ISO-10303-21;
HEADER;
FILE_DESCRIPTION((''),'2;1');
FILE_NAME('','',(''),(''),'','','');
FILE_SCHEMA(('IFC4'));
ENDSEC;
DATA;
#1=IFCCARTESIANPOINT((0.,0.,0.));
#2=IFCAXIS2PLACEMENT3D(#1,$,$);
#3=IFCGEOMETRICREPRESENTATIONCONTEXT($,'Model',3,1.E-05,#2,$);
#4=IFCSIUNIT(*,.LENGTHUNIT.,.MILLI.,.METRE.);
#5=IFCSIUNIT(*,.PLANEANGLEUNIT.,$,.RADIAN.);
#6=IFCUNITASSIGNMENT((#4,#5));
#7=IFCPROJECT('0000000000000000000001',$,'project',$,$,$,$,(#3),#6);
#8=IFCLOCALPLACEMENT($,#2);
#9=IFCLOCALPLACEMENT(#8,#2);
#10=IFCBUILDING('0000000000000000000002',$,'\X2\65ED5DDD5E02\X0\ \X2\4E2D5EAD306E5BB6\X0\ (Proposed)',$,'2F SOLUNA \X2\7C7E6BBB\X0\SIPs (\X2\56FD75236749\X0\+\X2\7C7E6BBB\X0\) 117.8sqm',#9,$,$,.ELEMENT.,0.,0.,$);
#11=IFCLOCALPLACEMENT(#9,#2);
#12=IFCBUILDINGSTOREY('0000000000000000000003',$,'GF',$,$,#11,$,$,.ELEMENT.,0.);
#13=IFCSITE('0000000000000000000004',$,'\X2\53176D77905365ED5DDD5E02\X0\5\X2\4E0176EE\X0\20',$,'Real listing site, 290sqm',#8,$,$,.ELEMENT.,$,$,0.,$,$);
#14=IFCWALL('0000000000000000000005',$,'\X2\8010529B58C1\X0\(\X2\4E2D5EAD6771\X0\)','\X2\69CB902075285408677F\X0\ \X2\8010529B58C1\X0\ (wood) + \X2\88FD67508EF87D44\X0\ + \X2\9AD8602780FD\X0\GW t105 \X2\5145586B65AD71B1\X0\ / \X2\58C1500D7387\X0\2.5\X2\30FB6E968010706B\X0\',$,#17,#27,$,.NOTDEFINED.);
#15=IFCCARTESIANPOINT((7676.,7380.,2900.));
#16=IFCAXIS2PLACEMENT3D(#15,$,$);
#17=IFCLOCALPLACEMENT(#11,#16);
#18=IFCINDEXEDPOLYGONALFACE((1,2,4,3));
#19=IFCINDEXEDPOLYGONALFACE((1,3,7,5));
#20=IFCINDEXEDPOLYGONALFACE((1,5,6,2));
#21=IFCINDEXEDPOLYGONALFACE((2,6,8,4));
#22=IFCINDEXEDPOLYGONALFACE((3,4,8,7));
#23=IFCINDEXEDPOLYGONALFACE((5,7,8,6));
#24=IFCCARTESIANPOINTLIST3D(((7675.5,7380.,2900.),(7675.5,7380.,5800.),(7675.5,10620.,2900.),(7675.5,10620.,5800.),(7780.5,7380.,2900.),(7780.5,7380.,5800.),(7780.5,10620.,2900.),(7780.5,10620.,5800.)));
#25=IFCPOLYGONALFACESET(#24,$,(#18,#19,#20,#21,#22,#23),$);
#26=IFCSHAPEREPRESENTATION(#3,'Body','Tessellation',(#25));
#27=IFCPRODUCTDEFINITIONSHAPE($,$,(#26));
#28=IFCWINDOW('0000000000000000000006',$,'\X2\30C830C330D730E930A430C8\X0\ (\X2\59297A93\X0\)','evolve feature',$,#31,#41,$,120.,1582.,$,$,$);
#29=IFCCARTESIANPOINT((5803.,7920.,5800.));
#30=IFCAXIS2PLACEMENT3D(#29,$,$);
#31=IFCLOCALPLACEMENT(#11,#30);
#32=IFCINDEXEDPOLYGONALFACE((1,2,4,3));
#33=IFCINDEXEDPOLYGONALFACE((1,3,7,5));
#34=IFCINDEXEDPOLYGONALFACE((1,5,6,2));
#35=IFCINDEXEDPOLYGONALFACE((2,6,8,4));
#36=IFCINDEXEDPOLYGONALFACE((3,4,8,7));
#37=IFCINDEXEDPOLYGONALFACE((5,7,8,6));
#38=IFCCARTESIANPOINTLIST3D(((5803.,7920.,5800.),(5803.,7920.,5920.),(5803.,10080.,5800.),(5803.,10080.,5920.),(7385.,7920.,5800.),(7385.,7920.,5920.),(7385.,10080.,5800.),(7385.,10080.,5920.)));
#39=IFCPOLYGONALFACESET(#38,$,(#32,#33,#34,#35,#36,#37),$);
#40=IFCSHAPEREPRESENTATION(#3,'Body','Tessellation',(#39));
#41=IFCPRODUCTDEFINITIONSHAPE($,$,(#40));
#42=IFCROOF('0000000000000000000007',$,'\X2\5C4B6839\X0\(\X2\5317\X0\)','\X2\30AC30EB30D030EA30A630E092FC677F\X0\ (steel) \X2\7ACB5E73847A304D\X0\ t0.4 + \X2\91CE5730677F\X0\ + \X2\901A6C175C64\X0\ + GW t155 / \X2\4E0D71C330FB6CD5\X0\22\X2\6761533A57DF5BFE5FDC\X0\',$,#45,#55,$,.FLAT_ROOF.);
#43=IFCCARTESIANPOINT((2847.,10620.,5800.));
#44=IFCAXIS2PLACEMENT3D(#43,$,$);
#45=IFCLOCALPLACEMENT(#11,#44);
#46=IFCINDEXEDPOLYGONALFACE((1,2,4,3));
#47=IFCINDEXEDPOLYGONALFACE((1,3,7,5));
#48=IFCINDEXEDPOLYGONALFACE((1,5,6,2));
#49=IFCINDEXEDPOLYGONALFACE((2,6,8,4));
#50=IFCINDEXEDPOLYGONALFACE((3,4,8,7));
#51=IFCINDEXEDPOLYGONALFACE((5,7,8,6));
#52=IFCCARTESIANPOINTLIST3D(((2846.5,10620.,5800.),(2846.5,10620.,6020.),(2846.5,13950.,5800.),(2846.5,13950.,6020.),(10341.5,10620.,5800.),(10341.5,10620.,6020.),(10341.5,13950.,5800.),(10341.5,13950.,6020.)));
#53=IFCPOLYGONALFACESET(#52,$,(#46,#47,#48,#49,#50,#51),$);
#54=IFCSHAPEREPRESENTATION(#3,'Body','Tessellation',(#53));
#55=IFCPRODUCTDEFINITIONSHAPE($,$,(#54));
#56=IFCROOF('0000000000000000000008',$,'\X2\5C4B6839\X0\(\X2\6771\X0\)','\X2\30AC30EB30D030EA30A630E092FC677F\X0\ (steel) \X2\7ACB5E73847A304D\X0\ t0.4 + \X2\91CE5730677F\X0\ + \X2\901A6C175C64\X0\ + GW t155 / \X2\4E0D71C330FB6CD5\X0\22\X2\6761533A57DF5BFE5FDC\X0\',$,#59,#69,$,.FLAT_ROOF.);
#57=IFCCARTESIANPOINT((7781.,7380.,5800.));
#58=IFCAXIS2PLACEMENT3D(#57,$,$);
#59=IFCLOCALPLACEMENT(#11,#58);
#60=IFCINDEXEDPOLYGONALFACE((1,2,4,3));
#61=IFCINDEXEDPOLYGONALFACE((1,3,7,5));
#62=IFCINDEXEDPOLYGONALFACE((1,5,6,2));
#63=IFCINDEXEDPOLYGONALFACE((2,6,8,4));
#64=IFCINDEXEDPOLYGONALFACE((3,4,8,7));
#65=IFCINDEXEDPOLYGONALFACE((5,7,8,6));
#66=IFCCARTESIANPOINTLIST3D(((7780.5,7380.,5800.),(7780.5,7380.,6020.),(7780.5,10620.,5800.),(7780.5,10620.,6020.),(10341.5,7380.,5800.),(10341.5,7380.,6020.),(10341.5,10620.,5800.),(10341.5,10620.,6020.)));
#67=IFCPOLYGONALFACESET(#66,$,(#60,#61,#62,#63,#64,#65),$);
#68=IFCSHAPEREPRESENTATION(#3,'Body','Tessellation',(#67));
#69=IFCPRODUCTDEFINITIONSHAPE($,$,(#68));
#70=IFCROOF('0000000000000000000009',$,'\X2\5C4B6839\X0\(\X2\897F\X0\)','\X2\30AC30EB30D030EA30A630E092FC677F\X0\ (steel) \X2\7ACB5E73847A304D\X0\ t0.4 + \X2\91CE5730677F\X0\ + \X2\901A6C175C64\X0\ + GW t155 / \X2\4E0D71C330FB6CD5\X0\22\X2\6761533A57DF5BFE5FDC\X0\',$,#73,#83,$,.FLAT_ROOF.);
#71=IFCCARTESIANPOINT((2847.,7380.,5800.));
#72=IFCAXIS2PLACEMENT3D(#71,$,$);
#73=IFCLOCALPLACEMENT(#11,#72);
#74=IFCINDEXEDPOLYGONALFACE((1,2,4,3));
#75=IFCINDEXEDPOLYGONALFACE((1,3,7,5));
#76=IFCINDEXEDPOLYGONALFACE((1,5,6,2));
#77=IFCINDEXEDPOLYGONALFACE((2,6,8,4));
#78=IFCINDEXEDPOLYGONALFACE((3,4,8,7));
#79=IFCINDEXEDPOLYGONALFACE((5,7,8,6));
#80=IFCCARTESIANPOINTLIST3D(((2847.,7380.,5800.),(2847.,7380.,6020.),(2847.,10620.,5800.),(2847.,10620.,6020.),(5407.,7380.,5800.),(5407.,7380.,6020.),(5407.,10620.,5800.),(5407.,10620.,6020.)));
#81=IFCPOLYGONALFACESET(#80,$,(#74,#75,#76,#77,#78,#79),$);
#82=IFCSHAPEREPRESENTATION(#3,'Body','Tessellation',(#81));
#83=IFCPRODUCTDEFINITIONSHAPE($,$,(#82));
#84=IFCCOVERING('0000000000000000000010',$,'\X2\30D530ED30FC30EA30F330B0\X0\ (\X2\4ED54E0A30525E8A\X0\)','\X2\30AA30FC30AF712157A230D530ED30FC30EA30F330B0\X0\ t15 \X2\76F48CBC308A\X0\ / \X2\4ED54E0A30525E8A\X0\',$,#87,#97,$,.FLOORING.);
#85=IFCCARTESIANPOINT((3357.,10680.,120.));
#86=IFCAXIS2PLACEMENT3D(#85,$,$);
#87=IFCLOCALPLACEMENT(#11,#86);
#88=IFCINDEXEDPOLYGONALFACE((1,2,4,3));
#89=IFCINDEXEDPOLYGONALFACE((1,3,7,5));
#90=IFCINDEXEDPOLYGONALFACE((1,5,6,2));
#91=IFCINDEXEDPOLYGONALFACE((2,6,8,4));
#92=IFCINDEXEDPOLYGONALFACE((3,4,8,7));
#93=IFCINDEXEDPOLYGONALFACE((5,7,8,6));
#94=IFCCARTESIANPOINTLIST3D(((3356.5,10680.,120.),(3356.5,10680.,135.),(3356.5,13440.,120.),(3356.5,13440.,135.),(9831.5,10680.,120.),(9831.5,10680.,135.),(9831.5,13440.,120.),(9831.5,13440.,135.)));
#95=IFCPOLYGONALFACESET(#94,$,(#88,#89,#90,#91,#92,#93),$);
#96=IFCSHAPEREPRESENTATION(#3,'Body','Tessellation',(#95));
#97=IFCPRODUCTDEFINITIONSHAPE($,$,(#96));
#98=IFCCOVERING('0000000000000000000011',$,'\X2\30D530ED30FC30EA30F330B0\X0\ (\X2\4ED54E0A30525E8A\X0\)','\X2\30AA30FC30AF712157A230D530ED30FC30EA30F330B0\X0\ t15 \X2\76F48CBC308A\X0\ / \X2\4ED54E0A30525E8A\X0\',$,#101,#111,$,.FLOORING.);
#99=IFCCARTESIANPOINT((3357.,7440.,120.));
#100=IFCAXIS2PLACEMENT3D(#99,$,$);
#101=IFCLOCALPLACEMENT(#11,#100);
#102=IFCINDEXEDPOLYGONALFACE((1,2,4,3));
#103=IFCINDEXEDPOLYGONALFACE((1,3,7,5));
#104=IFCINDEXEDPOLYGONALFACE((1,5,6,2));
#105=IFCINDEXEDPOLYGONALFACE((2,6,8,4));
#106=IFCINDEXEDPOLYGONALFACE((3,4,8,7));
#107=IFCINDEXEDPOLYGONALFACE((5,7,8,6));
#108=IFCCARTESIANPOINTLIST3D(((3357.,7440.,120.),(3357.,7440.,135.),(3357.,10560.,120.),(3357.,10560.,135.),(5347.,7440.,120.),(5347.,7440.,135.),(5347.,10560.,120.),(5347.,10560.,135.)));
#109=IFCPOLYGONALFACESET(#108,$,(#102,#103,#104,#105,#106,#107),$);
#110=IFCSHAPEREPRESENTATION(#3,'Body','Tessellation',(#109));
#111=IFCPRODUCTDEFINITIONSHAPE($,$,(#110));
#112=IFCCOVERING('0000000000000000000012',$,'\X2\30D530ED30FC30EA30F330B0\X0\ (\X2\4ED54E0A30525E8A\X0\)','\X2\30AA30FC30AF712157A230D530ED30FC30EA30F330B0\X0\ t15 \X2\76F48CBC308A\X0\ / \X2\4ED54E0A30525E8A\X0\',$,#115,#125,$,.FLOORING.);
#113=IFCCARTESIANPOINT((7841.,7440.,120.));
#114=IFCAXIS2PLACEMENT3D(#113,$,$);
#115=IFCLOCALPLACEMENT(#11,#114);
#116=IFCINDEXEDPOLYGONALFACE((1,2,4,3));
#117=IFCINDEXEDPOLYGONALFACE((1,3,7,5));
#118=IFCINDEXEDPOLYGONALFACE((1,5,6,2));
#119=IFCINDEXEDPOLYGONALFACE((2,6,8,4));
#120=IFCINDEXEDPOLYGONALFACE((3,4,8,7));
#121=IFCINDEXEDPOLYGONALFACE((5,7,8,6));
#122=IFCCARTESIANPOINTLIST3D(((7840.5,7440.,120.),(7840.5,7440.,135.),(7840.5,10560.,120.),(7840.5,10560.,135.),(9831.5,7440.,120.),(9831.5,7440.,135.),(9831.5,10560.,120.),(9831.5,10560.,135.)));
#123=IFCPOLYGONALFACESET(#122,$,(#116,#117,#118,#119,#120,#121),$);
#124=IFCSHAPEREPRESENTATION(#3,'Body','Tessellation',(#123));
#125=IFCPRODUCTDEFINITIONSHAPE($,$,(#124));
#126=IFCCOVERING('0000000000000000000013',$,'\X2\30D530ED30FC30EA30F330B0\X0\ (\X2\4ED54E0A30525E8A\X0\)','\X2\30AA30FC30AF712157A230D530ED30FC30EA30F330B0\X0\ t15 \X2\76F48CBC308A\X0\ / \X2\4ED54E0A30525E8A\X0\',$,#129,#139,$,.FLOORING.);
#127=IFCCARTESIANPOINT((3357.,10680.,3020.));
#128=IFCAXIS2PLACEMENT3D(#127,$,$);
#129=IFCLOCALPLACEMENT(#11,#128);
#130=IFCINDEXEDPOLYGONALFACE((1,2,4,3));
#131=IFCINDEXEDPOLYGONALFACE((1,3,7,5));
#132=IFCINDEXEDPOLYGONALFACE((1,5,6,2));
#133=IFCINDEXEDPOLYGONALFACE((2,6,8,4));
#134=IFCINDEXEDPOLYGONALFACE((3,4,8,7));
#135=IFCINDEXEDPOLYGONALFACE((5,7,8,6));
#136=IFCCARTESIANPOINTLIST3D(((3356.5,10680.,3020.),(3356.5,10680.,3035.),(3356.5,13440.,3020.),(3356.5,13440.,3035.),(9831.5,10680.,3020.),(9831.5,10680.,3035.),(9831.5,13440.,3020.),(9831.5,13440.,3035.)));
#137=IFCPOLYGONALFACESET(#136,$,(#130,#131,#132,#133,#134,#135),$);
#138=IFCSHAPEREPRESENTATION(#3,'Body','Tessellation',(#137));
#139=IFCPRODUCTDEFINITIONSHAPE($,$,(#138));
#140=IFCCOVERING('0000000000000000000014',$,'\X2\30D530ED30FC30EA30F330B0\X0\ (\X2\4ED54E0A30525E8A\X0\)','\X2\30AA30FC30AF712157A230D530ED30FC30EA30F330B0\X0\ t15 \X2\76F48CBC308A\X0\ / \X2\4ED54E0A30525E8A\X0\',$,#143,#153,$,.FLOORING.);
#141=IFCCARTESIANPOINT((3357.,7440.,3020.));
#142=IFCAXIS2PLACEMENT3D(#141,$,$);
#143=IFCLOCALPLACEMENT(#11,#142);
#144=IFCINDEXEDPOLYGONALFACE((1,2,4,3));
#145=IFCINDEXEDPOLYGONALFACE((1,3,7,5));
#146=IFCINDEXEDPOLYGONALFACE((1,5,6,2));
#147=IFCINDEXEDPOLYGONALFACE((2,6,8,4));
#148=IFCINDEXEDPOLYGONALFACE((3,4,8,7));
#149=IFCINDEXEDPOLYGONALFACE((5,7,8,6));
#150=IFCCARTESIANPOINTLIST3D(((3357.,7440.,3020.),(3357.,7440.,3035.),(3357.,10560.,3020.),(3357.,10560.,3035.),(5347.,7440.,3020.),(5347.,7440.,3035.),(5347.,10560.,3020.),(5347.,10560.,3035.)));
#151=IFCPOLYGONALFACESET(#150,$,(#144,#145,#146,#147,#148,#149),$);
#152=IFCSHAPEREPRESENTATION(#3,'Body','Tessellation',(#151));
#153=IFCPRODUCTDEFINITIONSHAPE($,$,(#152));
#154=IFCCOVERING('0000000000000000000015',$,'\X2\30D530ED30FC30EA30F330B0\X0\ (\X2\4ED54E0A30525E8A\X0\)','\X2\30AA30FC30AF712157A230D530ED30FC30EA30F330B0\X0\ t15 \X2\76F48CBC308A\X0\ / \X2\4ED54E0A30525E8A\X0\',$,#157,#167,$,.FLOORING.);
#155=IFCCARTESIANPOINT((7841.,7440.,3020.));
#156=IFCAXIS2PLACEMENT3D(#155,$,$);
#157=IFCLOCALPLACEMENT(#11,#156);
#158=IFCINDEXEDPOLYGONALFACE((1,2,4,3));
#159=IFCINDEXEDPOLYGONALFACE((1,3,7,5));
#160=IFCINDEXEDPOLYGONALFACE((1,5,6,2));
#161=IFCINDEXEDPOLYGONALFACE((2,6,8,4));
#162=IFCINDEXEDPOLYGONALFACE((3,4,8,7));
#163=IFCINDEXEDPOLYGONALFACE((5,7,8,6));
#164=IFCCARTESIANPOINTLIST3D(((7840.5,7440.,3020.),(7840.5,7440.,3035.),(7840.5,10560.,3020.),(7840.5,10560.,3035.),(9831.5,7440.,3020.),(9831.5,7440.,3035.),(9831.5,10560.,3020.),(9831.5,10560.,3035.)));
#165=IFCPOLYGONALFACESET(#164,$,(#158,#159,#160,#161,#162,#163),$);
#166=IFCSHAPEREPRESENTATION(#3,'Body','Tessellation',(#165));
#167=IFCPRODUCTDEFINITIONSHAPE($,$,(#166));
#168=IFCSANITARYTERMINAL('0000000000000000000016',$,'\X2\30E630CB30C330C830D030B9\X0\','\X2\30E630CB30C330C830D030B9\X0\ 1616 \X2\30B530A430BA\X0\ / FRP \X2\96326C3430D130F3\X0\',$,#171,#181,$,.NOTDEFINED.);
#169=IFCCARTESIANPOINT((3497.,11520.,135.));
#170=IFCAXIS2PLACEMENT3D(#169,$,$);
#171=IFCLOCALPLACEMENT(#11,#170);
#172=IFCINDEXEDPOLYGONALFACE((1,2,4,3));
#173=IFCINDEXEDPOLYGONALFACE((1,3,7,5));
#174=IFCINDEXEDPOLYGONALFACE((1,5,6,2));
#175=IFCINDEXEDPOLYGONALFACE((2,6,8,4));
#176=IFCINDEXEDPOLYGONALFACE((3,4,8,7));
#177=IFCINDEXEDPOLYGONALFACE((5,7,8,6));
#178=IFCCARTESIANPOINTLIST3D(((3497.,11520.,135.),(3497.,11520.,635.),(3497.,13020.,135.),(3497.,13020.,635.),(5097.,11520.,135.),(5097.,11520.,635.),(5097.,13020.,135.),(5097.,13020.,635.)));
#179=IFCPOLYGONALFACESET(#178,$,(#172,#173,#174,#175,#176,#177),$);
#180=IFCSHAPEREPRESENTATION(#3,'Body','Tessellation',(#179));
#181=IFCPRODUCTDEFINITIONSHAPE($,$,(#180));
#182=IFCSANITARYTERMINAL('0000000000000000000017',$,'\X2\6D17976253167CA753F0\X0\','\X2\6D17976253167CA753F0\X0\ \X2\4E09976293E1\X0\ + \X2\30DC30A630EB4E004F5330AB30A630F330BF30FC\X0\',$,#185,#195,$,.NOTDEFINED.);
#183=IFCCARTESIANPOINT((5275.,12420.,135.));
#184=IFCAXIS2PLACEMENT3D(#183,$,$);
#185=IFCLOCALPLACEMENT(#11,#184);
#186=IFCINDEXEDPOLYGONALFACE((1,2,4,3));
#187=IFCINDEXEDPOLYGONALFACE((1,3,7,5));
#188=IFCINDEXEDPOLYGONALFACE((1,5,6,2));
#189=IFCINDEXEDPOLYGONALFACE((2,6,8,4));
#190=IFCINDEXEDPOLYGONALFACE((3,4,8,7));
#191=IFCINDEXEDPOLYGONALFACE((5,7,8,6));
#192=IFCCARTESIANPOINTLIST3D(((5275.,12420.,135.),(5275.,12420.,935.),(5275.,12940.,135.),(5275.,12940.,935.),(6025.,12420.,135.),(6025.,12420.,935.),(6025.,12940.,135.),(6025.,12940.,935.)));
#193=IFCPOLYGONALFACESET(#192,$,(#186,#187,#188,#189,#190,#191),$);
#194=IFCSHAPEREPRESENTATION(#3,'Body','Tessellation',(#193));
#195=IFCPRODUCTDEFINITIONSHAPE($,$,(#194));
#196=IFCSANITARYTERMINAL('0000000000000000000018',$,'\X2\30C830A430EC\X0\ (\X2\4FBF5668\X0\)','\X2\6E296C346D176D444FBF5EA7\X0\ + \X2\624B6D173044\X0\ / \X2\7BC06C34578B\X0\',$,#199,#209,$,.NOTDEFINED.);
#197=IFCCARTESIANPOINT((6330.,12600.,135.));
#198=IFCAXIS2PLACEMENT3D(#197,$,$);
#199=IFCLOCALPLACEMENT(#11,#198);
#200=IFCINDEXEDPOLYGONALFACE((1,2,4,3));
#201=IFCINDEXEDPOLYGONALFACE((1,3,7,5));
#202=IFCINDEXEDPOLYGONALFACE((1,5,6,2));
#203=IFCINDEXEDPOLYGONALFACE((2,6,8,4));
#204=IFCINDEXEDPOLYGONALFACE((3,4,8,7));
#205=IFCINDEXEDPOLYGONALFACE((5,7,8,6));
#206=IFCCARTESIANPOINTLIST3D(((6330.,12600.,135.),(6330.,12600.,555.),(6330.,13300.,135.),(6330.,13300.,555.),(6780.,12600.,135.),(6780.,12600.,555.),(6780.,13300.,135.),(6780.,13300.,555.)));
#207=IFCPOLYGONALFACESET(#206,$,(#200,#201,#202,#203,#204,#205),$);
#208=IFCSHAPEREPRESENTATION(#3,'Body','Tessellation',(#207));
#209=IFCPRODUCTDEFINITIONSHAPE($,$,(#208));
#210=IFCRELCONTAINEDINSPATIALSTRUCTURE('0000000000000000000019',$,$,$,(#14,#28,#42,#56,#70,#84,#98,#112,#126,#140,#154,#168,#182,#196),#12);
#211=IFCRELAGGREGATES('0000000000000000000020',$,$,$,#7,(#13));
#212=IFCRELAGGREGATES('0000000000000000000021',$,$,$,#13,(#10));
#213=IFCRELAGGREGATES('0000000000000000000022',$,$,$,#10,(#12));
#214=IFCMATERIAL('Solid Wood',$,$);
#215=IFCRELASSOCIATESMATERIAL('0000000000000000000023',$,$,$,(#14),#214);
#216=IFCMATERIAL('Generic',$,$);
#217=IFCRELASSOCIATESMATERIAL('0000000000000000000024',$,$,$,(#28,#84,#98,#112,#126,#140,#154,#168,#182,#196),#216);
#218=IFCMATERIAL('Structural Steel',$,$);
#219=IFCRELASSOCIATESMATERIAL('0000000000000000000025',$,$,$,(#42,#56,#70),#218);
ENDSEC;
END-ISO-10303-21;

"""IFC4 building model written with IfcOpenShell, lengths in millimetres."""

from ifc_helpers import new_model, si_unit, frame, frame_2d, origin, place, context, project, spatial, rectangle, extrude, material, element, save


model = new_model("IFC4")

# Units and contexts
model_context = context("Model", 3, precision=1e-05, world=origin())
ifc_project = project(units=[si_unit("LENGTHUNIT", "METRE", prefix="MILLI"), si_unit("PLANEANGLEUNIT", "RADIAN")], contexts=[model_context])

# Site, building, storey
site_placement = place(None, origin())
site = spatial("IfcSite", under=ifc_project, at=site_placement, Name="北海道旭川市5丁目20", ObjectType="Real listing site, 290sqm", CompositionType="ELEMENT", RefElevation=0.0)
building_placement = place(site_placement, origin())
building = spatial("IfcBuilding", under=site, at=building_placement, Name="旭川市 中庭の家 (Proposed)", ObjectType="2F SOLUNA 籾殻SIPs (国産杉+籾殻) 117.8sqm", CompositionType="ELEMENT", ElevationOfRefHeight=0.0, ElevationOfTerrain=0.0)
storey_placement = place(building_placement, origin())
storey = spatial("IfcBuildingStorey", under=building, at=storey_placement, Name="GF", CompositionType="ELEMENT", Elevation=0.0)

# Shared definitions
ifc_material_1 = material(Name="Solid Wood")

# Wall
wall_1_placement = place(storey_placement, frame((7676.0, 7380.0, 2900.0)))
element("IfcWall", 1, at=wall_1_placement, inside=storey, material=ifc_material_1, Name="耐力壁(中庭東)", Description="構造用合板 耐力壁 (wood) + 製材軸組 + 高性能GW t105 充填断熱 / 壁倍率2.5・準耐火", PredefinedType="NOTDEFINED", context=model_context, shape_type="SweptSolid", body=[
    extrude(rectangle(XDim=105.0, YDim=3240.0, at=frame_2d((52.0, 1620.0))), frame((7676.0, 7380.0, 2900.0)), (0.0, 0.0, 1.0), 2900.0),
])

# Window
ifc_material_2 = material(Name="Generic")
window_1_placement = place(storey_placement, frame((5803.0, 7920.0, 5800.0)))
element("IfcWindow", 2, at=window_1_placement, inside=storey, material=ifc_material_2, Name="トップライト (天窓)", Description="evolve feature", OverallHeight=120.0, OverallWidth=1582.0, context=model_context, shape_type="SweptSolid", body=[
    extrude(rectangle(XDim=1582.0, YDim=2160.0, at=frame_2d((791.0, 1080.0))), frame((5803.0, 7920.0, 5800.0)), (0.0, 0.0, 1.0), 120.0),
])

# Roofs
ifc_material_3 = material(Name="Structural Steel")
roof_1_placement = place(storey_placement, frame((2847.0, 10620.0, 5800.0)))
element("IfcRoof", 3, at=roof_1_placement, inside=storey, material=ifc_material_3, Name="屋根(北)", Description="ガルバリウム鋼板 (steel) 立平葺き t0.4 + 野地板 + 通気層 + GW t155 / 不燃・法22条区域対応", PredefinedType="FLAT_ROOF", context=model_context, shape_type="SweptSolid", body=[
    extrude(rectangle(XDim=7495.0, YDim=3330.0, at=frame_2d((3747.0, 1665.0))), frame((2847.0, 10620.0, 5800.0)), (0.0, 0.0, 1.0), 220.0),
])
roof_2_placement = place(storey_placement, frame((7781.0, 7380.0, 5800.0)))
element("IfcRoof", 4, at=roof_2_placement, inside=storey, material=ifc_material_3, Name="屋根(東)", Description="ガルバリウム鋼板 (steel) 立平葺き t0.4 + 野地板 + 通気層 + GW t155 / 不燃・法22条区域対応", PredefinedType="FLAT_ROOF", context=model_context, shape_type="SweptSolid", body=[
    extrude(rectangle(XDim=2561.0, YDim=3240.0, at=frame_2d((1280.0, 1620.0))), frame((7781.0, 7380.0, 5800.0)), (0.0, 0.0, 1.0), 220.0),
])
roof_3_placement = place(storey_placement, frame((2847.0, 7380.0, 5800.0)))
element("IfcRoof", 5, at=roof_3_placement, inside=storey, material=ifc_material_3, Name="屋根(西)", Description="ガルバリウム鋼板 (steel) 立平葺き t0.4 + 野地板 + 通気層 + GW t155 / 不燃・法22条区域対応", PredefinedType="FLAT_ROOF", context=model_context, shape_type="SweptSolid", body=[
    extrude(rectangle(XDim=2560.0, YDim=3240.0, at=frame_2d((1280.0, 1620.0))), frame((2847.0, 7380.0, 5800.0)), (0.0, 0.0, 1.0), 220.0),
])

# Coverings
covering_1_placement = place(storey_placement, frame((3357.0, 10680.0, 120.0)))
element("IfcCovering", 6, at=covering_1_placement, inside=storey, material=ifc_material_2, Name="フローリング (仕上げ床)", Description="オーク無垢フローリング t15 直貼り / 仕上げ床", PredefinedType="FLOORING", context=model_context, shape_type="SweptSolid", body=[
    extrude(rectangle(XDim=6475.0, YDim=2760.0, at=frame_2d((3237.0, 1380.0))), frame((3357.0, 10680.0, 120.0)), (0.0, 0.0, 1.0), 15.0),
])
covering_2_placement = place(storey_placement, frame((3357.0, 7440.0, 120.0)))
element("IfcCovering", 7, at=covering_2_placement, inside=storey, material=ifc_material_2, Name="フローリング (仕上げ床)", Description="オーク無垢フローリング t15 直貼り / 仕上げ床", PredefinedType="FLOORING", context=model_context, shape_type="SweptSolid", body=[
    extrude(rectangle(XDim=1990.0, YDim=3120.0, at=frame_2d((995.0, 1560.0))), frame((3357.0, 7440.0, 120.0)), (0.0, 0.0, 1.0), 15.0),
])
covering_3_placement = place(storey_placement, frame((7841.0, 7440.0, 120.0)))
element("IfcCovering", 8, at=covering_3_placement, inside=storey, material=ifc_material_2, Name="フローリング (仕上げ床)", Description="オーク無垢フローリング t15 直貼り / 仕上げ床", PredefinedType="FLOORING", context=model_context, shape_type="SweptSolid", body=[
    extrude(rectangle(XDim=1991.0, YDim=3120.0, at=frame_2d((995.0, 1560.0))), frame((7841.0, 7440.0, 120.0)), (0.0, 0.0, 1.0), 15.0),
])
covering_4_placement = place(storey_placement, frame((3357.0, 10680.0, 3020.0)))
element("IfcCovering", 9, at=covering_4_placement, inside=storey, material=ifc_material_2, Name="フローリング (仕上げ床)", Description="オーク無垢フローリング t15 直貼り / 仕上げ床", PredefinedType="FLOORING", context=model_context, shape_type="SweptSolid", body=[
    extrude(rectangle(XDim=6475.0, YDim=2760.0, at=frame_2d((3237.0, 1380.0))), frame((3357.0, 10680.0, 3020.0)), (0.0, 0.0, 1.0), 15.0),
])
covering_5_placement = place(storey_placement, frame((3357.0, 7440.0, 3020.0)))
element("IfcCovering", 10, at=covering_5_placement, inside=storey, material=ifc_material_2, Name="フローリング (仕上げ床)", Description="オーク無垢フローリング t15 直貼り / 仕上げ床", PredefinedType="FLOORING", context=model_context, shape_type="SweptSolid", body=[
    extrude(rectangle(XDim=1990.0, YDim=3120.0, at=frame_2d((995.0, 1560.0))), frame((3357.0, 7440.0, 3020.0)), (0.0, 0.0, 1.0), 15.0),
])
covering_6_placement = place(storey_placement, frame((7841.0, 7440.0, 3020.0)))
element("IfcCovering", 11, at=covering_6_placement, inside=storey, material=ifc_material_2, Name="フローリング (仕上げ床)", Description="オーク無垢フローリング t15 直貼り / 仕上げ床", PredefinedType="FLOORING", context=model_context, shape_type="SweptSolid", body=[
    extrude(rectangle(XDim=1991.0, YDim=3120.0, at=frame_2d((995.0, 1560.0))), frame((7841.0, 7440.0, 3020.0)), (0.0, 0.0, 1.0), 15.0),
])

# Sanitary terminals
sanitary_terminal_1_placement = place(storey_placement, frame((3497.0, 11520.0, 135.0)))
element("IfcSanitaryTerminal", 12, at=sanitary_terminal_1_placement, inside=storey, material=ifc_material_2, Name="ユニットバス", Description="ユニットバス 1616 サイズ / FRP 防水パン", PredefinedType="NOTDEFINED", context=model_context, shape_type="SweptSolid", body=[
    extrude(rectangle(XDim=1600.0, YDim=1500.0, at=frame_2d((800.0, 750.0))), frame((3497.0, 11520.0, 135.0)), (0.0, 0.0, 1.0), 500.0),
])
sanitary_terminal_2_placement = place(storey_placement, frame((5275.0, 12420.0, 135.0)))
element("IfcSanitaryTerminal", 13, at=sanitary_terminal_2_placement, inside=storey, material=ifc_material_2, Name="洗面化粧台", Description="洗面化粧台 三面鏡 + ボウル一体カウンター", PredefinedType="NOTDEFINED", context=model_context, shape_type="SweptSolid", body=[
    extrude(rectangle(XDim=750.0, YDim=520.0, at=frame_2d((375.0, 260.0))), frame((5275.0, 12420.0, 135.0)), (0.0, 0.0, 1.0), 800.0),
])
sanitary_terminal_3_placement = place(storey_placement, frame((6330.0, 12600.0, 135.0)))
element("IfcSanitaryTerminal", 14, at=sanitary_terminal_3_placement, inside=storey, material=ifc_material_2, Name="トイレ (便器)", Description="温水洗浄便座 + 手洗い / 節水型", PredefinedType="NOTDEFINED", context=model_context, shape_type="SweptSolid", body=[
    extrude(rectangle(XDim=450.0, YDim=700.0, at=frame_2d((225.0, 350.0))), frame((6330.0, 12600.0, 135.0)), (0.0, 0.0, 1.0), 420.0),
])

save(model, "model.ifc")
